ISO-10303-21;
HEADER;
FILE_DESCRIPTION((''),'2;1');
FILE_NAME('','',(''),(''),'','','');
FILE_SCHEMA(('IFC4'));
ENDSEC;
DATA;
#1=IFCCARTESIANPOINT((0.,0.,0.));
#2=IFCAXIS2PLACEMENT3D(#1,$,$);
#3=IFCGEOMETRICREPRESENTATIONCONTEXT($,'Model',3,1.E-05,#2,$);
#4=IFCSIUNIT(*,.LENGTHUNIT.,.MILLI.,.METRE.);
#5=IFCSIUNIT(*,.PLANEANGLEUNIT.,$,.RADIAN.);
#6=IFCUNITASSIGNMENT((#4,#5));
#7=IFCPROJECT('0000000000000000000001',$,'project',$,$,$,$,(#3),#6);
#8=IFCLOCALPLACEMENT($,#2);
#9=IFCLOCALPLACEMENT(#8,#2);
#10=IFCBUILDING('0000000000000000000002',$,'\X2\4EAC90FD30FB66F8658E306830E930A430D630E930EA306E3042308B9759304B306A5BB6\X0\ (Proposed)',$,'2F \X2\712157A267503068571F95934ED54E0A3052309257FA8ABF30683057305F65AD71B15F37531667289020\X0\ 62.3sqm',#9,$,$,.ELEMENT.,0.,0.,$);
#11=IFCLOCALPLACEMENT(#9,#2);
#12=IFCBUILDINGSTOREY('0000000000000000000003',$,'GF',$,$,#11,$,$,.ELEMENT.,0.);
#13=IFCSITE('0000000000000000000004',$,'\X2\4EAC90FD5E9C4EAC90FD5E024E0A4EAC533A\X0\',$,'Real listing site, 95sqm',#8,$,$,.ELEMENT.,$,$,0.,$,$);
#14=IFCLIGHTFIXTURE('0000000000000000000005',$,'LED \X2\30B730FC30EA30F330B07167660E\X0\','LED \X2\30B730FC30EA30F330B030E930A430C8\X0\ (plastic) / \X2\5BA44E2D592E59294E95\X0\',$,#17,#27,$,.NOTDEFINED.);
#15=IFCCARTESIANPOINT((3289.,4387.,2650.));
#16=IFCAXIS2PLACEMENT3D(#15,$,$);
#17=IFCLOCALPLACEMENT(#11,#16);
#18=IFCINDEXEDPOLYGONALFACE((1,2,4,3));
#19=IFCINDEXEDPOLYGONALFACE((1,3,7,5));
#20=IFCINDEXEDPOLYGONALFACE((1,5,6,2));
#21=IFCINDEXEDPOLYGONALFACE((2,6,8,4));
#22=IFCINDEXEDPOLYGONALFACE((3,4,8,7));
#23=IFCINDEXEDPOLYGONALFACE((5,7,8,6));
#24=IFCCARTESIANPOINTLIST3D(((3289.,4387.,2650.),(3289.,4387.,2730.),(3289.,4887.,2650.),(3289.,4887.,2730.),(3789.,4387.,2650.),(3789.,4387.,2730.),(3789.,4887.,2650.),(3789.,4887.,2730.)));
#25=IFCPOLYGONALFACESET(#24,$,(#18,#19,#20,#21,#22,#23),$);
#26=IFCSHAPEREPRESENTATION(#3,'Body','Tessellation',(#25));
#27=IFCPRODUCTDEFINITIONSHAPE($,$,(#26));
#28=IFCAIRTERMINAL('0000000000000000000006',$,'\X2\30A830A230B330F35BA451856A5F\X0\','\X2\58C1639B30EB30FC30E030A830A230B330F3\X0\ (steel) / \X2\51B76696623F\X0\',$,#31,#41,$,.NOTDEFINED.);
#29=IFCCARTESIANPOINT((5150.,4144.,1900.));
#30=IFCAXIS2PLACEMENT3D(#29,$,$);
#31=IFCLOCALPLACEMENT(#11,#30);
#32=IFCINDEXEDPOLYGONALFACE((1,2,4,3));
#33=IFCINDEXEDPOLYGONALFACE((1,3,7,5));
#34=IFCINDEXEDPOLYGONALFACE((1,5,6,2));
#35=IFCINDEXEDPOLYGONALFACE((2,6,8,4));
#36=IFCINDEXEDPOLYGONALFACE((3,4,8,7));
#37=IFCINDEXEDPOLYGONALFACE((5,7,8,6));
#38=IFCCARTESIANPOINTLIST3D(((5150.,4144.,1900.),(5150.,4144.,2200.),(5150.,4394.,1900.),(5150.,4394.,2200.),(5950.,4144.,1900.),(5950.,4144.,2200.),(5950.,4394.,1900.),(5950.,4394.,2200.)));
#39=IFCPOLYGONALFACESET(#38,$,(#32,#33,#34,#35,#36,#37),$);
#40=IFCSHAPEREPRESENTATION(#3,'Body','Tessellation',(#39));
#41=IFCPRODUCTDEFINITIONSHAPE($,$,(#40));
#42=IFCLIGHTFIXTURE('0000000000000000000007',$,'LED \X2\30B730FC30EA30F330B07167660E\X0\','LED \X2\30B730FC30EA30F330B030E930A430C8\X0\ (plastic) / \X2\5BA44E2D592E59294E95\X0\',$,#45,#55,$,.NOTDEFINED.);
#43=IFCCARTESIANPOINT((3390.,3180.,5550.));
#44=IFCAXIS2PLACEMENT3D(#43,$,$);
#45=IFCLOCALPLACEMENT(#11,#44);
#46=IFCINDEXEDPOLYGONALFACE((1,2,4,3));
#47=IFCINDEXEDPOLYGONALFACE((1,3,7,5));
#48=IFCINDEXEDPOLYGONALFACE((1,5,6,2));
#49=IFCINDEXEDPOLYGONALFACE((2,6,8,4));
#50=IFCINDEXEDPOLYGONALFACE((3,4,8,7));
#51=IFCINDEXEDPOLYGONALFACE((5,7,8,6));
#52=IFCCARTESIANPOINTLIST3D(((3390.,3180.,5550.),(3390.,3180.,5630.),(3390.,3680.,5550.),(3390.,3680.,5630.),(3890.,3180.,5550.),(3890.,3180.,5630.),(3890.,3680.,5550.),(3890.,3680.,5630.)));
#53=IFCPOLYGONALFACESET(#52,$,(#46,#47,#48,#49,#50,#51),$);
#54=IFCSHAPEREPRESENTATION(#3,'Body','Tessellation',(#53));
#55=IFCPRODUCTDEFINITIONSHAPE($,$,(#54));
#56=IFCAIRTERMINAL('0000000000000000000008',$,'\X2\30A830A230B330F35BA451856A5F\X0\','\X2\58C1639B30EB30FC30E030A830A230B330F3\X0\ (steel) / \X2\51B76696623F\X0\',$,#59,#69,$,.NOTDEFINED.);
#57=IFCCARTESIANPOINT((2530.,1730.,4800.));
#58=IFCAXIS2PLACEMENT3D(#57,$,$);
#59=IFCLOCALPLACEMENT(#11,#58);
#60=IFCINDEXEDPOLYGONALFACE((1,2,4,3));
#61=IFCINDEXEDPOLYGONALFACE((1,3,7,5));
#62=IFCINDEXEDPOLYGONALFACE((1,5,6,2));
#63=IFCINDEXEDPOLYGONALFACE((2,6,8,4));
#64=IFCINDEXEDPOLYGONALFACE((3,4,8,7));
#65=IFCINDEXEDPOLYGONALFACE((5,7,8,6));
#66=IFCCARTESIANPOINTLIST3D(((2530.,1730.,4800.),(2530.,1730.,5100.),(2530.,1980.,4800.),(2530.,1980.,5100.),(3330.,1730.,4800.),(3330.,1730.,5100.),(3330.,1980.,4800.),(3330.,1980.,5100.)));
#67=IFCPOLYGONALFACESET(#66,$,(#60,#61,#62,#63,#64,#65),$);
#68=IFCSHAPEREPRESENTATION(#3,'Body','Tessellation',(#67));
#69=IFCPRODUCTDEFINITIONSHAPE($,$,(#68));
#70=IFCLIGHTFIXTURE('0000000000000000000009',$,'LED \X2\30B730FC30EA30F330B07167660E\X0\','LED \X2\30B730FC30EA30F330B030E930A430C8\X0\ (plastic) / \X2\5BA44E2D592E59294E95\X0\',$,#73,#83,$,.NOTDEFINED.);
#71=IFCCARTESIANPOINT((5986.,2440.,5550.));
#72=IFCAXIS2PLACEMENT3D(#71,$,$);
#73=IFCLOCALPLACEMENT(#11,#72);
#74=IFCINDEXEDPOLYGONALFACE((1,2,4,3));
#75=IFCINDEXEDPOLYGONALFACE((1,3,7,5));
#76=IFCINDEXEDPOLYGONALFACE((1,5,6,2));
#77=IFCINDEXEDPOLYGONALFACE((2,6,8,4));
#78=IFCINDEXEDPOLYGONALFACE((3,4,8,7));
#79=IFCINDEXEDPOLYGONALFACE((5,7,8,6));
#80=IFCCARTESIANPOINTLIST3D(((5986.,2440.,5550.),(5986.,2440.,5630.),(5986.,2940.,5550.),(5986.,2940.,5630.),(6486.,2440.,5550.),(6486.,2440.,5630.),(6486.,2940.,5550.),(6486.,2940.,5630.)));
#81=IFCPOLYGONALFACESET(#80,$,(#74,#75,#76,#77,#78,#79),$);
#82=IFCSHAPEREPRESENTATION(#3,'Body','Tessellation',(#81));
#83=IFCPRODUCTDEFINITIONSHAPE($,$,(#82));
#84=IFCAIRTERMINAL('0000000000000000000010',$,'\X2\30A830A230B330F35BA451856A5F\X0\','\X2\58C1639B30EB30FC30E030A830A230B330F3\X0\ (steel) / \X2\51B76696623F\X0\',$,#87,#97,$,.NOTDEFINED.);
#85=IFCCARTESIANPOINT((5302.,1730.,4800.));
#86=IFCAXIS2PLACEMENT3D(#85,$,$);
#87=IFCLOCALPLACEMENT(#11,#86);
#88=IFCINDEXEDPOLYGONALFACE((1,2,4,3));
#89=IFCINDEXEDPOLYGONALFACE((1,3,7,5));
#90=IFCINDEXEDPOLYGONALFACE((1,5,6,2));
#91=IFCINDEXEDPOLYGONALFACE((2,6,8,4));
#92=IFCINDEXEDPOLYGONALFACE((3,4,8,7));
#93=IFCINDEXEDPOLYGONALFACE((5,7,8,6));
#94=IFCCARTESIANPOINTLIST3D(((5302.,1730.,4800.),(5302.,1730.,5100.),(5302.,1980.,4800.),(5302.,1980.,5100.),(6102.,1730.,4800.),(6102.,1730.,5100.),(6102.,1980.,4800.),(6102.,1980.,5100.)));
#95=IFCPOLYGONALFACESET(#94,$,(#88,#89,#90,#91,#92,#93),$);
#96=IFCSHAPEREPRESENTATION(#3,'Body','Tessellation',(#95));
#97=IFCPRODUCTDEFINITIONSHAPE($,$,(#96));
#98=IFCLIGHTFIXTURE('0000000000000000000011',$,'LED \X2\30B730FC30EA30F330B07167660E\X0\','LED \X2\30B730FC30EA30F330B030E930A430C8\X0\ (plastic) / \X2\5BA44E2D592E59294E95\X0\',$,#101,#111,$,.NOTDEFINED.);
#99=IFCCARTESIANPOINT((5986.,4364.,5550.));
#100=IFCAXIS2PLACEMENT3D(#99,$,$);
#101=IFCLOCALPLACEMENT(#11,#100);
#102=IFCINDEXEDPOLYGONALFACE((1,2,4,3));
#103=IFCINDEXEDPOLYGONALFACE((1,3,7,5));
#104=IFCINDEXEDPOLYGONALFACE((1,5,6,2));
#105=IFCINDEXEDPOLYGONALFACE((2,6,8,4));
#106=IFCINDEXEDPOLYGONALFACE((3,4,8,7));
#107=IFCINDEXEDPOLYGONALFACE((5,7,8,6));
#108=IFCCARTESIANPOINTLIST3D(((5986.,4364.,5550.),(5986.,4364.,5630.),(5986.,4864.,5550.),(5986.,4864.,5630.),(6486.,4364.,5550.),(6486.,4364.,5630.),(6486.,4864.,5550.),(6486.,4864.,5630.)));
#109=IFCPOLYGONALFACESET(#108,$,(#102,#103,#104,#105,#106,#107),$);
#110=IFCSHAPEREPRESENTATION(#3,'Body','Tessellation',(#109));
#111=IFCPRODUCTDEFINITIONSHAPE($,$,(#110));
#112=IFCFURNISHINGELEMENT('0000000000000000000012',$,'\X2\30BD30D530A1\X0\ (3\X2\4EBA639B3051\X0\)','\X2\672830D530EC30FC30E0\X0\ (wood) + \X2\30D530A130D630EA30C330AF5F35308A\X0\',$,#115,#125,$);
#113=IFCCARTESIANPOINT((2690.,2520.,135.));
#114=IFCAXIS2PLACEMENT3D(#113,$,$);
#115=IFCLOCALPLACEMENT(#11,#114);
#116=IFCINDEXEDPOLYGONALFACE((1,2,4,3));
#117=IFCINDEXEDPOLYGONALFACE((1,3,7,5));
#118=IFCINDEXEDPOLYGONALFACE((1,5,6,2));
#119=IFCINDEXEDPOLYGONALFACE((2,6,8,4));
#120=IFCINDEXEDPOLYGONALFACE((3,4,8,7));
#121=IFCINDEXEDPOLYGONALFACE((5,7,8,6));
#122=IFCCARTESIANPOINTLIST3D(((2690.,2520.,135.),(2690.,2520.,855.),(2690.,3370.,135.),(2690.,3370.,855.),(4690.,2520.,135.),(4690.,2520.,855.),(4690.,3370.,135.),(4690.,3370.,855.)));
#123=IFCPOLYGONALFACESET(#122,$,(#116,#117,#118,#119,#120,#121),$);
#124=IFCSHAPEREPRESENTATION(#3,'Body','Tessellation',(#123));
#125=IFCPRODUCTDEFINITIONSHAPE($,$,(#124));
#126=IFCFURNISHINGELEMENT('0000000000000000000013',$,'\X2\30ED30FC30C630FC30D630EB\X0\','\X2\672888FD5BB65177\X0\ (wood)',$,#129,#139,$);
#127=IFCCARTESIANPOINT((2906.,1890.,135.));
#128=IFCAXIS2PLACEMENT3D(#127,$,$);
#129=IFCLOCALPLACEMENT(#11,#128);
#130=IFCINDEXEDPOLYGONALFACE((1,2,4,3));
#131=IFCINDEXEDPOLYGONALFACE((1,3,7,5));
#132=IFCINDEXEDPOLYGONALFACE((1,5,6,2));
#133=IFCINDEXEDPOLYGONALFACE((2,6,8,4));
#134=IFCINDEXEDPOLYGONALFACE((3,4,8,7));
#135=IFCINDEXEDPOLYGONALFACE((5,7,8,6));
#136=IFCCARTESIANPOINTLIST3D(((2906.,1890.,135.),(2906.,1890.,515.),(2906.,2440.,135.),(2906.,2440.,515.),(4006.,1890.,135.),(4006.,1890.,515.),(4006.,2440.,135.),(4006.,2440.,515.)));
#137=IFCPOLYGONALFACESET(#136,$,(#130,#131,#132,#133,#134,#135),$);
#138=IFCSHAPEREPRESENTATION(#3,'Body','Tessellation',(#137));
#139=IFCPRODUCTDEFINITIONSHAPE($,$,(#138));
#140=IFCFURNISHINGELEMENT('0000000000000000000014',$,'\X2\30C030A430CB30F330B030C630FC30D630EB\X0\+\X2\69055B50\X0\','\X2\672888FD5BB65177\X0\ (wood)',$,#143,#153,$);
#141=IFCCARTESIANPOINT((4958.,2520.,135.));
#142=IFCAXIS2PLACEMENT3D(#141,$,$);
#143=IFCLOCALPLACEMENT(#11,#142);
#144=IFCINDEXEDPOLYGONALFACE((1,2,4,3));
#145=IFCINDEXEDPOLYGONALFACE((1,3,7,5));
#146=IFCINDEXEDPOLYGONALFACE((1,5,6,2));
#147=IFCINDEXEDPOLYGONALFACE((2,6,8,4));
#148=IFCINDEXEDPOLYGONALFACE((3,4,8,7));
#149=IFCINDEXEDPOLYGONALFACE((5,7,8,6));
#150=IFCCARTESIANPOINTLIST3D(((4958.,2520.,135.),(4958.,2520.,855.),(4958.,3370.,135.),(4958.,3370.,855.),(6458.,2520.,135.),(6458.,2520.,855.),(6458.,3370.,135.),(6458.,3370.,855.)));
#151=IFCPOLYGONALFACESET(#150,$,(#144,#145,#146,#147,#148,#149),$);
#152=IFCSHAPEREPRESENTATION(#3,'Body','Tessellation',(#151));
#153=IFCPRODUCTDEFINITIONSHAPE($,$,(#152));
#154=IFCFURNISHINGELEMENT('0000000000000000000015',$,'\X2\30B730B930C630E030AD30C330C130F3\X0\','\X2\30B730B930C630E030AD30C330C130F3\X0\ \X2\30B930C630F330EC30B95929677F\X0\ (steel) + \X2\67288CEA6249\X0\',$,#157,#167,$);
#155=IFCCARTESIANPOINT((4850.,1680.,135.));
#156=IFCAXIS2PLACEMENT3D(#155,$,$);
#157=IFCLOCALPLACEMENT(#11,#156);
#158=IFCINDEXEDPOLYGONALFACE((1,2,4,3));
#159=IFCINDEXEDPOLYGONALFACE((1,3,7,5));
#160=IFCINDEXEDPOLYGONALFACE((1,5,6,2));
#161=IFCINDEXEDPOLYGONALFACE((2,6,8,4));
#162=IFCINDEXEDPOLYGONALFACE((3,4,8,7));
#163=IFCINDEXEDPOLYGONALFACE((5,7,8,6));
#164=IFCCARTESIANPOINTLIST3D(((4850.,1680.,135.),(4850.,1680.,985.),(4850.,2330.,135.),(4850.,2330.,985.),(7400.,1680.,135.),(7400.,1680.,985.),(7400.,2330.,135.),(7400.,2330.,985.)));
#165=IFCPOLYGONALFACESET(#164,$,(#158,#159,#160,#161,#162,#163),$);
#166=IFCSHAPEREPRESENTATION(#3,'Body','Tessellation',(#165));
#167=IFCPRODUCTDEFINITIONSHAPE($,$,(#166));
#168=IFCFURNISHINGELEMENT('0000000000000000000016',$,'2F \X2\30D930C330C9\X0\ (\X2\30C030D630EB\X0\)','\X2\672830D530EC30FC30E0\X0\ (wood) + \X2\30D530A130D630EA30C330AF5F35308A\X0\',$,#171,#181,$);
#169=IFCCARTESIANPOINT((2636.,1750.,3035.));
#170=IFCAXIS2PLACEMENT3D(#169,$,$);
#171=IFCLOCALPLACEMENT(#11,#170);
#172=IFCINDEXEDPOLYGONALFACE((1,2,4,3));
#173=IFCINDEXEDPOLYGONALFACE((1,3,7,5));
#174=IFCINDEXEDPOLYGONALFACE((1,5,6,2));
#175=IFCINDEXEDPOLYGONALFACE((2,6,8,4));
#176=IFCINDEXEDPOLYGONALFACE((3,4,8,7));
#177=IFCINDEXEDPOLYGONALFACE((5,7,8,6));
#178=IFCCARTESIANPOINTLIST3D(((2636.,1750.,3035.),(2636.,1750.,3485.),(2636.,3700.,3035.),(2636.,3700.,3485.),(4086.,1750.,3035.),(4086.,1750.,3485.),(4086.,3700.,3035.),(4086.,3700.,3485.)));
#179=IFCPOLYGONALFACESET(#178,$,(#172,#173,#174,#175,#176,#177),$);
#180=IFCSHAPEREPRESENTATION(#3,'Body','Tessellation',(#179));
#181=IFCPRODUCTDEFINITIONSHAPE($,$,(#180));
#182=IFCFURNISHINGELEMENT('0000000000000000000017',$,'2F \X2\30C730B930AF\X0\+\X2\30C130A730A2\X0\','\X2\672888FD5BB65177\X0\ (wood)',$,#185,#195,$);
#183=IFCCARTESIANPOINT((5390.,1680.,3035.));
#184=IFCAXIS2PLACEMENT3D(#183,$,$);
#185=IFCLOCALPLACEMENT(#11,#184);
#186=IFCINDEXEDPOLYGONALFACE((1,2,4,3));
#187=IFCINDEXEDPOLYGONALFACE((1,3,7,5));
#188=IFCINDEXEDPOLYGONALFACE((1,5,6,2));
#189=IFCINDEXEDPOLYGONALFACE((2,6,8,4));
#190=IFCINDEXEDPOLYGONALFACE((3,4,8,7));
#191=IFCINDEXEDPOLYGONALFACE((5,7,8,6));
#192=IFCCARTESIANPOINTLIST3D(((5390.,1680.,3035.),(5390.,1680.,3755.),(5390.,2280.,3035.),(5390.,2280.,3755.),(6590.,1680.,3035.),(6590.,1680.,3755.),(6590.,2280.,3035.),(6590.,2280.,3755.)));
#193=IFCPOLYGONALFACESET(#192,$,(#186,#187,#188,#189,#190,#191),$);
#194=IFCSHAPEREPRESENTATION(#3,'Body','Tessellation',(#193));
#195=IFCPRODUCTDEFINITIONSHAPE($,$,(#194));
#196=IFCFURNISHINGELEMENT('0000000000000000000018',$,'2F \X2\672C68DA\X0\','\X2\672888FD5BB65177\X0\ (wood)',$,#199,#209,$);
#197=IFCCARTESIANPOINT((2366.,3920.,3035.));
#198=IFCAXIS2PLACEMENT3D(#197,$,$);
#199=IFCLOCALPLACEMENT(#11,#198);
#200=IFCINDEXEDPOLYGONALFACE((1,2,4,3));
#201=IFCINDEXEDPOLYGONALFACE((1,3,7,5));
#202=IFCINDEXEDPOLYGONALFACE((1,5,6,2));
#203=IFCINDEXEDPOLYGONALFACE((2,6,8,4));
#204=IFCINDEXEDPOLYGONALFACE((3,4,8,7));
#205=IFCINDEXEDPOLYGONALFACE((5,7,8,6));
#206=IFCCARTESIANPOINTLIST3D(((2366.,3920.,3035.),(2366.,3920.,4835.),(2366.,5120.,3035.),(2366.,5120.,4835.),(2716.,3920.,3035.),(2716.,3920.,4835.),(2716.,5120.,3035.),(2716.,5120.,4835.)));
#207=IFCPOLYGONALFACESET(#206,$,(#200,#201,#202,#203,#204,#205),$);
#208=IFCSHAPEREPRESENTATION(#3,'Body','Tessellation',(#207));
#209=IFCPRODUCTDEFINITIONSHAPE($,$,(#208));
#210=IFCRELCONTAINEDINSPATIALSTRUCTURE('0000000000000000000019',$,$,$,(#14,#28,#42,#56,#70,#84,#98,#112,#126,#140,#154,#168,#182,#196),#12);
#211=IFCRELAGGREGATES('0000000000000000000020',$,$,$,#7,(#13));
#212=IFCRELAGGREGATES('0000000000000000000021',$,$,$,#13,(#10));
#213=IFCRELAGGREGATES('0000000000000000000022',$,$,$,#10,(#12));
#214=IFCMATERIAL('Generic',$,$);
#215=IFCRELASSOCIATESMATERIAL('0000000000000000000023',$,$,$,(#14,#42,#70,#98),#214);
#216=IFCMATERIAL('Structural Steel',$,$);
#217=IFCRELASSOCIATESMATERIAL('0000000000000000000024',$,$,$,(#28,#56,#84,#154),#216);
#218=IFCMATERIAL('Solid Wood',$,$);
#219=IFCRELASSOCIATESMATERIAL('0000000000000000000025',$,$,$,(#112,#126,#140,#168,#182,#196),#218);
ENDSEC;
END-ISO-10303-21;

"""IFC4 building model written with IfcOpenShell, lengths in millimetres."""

from ifc_helpers import new_model, si_unit, frame, frame_2d, origin, place, context, project, spatial, rectangle, extrude, material, element, save


model = new_model("IFC4")

# Units and contexts
model_context = context("Model", 3, precision=1e-05, world=origin())
ifc_project = project(units=[si_unit("LENGTHUNIT", "METRE", prefix="MILLI"), si_unit("PLANEANGLEUNIT", "RADIAN")], contexts=[model_context])

# Site, building, storey
site_placement = place(None, origin())
site = spatial("IfcSite", under=ifc_project, at=site_placement, Name="京都府京都市上京区", ObjectType="Real listing site, 95sqm", CompositionType="ELEMENT", RefElevation=0.0)
building_placement = place(site_placement, origin())
building = spatial("IfcBuilding", under=site, at=building_placement, Name="京都・書斎とライブラリのある静かな家 (Proposed)", ObjectType="2F 無垢材と土間仕上げを基調とした断熱強化木造 62.3sqm", CompositionType="ELEMENT", ElevationOfRefHeight=0.0, ElevationOfTerrain=0.0)
storey_placement = place(building_placement, origin())
storey = spatial("IfcBuildingStorey", under=building, at=storey_placement, Name="GF", CompositionType="ELEMENT", Elevation=0.0)

# Shared definitions
ifc_material_1 = material(Name="Solid Wood")

# Shared definitions
ifc_material_2 = material(Name="Structural Steel")

# Shared definitions
ifc_material_3 = material(Name="Generic")

# Light fixture
light_fixture_1_placement = place(storey_placement, frame((3289.0, 4387.0, 2650.0)))
element("IfcLightFixture", 1, at=light_fixture_1_placement, inside=storey, material=ifc_material_3, Name="LED シーリング照明", Description="LED シーリングライト (plastic) / 室中央天井", PredefinedType="NOTDEFINED", context=model_context, shape_type="SweptSolid", body=[
    extrude(rectangle(XDim=500.0, YDim=500.0, at=frame_2d((250.0, 250.0))), frame((3289.0, 4387.0, 2650.0)), (0.0, 0.0, 1.0), 80.0),
])

# Air terminal
air_terminal_1_placement = place(storey_placement, frame((5150.0, 4144.0, 1900.0)))
element("IfcAirTerminal", 2, at=air_terminal_1_placement, inside=storey, material=ifc_material_2, Name="エアコン室内機", Description="壁掛ルームエアコン (steel) / 冷暖房", PredefinedType="NOTDEFINED", context=model_context, shape_type="SweptSolid", body=[
    extrude(rectangle(XDim=800.0, YDim=250.0, at=frame_2d((400.0, 125.0))), frame((5150.0, 4144.0, 1900.0)), (0.0, 0.0, 1.0), 300.0),
])

# Light fixture
light_fixture_2_placement = place(storey_placement, frame((3390.0, 3180.0, 5550.0)))
element("IfcLightFixture", 3, at=light_fixture_2_placement, inside=storey, material=ifc_material_3, Name="LED シーリング照明", Description="LED シーリングライト (plastic) / 室中央天井", PredefinedType="NOTDEFINED", context=model_context, shape_type="SweptSolid", body=[
    extrude(rectangle(XDim=500.0, YDim=500.0, at=frame_2d((250.0, 250.0))), frame((3390.0, 3180.0, 5550.0)), (0.0, 0.0, 1.0), 80.0),
])

# Air terminal
air_terminal_2_placement = place(storey_placement, frame((2530.0, 1730.0, 4800.0)))
element("IfcAirTerminal", 4, at=air_terminal_2_placement, inside=storey, material=ifc_material_2, Name="エアコン室内機", Description="壁掛ルームエアコン (steel) / 冷暖房", PredefinedType="NOTDEFINED", context=model_context, shape_type="SweptSolid", body=[
    extrude(rectangle(XDim=800.0, YDim=250.0, at=frame_2d((400.0, 125.0))), frame((2530.0, 1730.0, 4800.0)), (0.0, 0.0, 1.0), 300.0),
])

# Light fixture
light_fixture_3_placement = place(storey_placement, frame((5986.0, 2440.0, 5550.0)))
element("IfcLightFixture", 5, at=light_fixture_3_placement, inside=storey, material=ifc_material_3, Name="LED シーリング照明", Description="LED シーリングライト (plastic) / 室中央天井", PredefinedType="NOTDEFINED", context=model_context, shape_type="SweptSolid", body=[
    extrude(rectangle(XDim=500.0, YDim=500.0, at=frame_2d((250.0, 250.0))), frame((5986.0, 2440.0, 5550.0)), (0.0, 0.0, 1.0), 80.0),
])

# Air terminal
air_terminal_3_placement = place(storey_placement, frame((5302.0, 1730.0, 4800.0)))
element("IfcAirTerminal", 6, at=air_terminal_3_placement, inside=storey, material=ifc_material_2, Name="エアコン室内機", Description="壁掛ルームエアコン (steel) / 冷暖房", PredefinedType="NOTDEFINED", context=model_context, shape_type="SweptSolid", body=[
    extrude(rectangle(XDim=800.0, YDim=250.0, at=frame_2d((400.0, 125.0))), frame((5302.0, 1730.0, 4800.0)), (0.0, 0.0, 1.0), 300.0),
])

# Light fixture
light_fixture_4_placement = place(storey_placement, frame((5986.0, 4364.0, 5550.0)))
element("IfcLightFixture", 7, at=light_fixture_4_placement, inside=storey, material=ifc_material_3, Name="LED シーリング照明", Description="LED シーリングライト (plastic) / 室中央天井", PredefinedType="NOTDEFINED", context=model_context, shape_type="SweptSolid", body=[
    extrude(rectangle(XDim=500.0, YDim=500.0, at=frame_2d((250.0, 250.0))), frame((5986.0, 4364.0, 5550.0)), (0.0, 0.0, 1.0), 80.0),
])

# Furnishing elements
furnishing_1_placement = place(storey_placement, frame((2690.0, 2520.0, 135.0)))
element("IfcFurnishingElement", 8, at=furnishing_1_placement, inside=storey, material=ifc_material_1, Name="ソファ (3人掛け)", Description="木フレーム (wood) + ファブリック張り", context=model_context, shape_type="SweptSolid", body=[
    extrude(rectangle(XDim=2000.0, YDim=850.0, at=frame_2d((1000.0, 425.0))), frame((2690.0, 2520.0, 135.0)), (0.0, 0.0, 1.0), 720.0),
])
furnishing_2_placement = place(storey_placement, frame((2906.0, 1890.0, 135.0)))
element("IfcFurnishingElement", 9, at=furnishing_2_placement, inside=storey, material=ifc_material_1, Name="ローテーブル", Description="木製家具 (wood)", context=model_context, shape_type="SweptSolid", body=[
    extrude(rectangle(XDim=1100.0, YDim=550.0, at=frame_2d((550.0, 275.0))), frame((2906.0, 1890.0, 135.0)), (0.0, 0.0, 1.0), 380.0),
])
furnishing_3_placement = place(storey_placement, frame((4958.0, 2520.0, 135.0)))
element("IfcFurnishingElement", 10, at=furnishing_3_placement, inside=storey, material=ifc_material_1, Name="ダイニングテーブル+椅子", Description="木製家具 (wood)", context=model_context, shape_type="SweptSolid", body=[
    extrude(rectangle(XDim=1500.0, YDim=850.0, at=frame_2d((750.0, 425.0))), frame((4958.0, 2520.0, 135.0)), (0.0, 0.0, 1.0), 720.0),
])
furnishing_4_placement = place(storey_placement, frame((4850.0, 1680.0, 135.0)))
element("IfcFurnishingElement", 11, at=furnishing_4_placement, inside=storey, material=ifc_material_2, Name="システムキッチン", Description="システムキッチン ステンレス天板 (steel) + 木質扉", context=model_context, shape_type="SweptSolid", body=[
    extrude(rectangle(XDim=2550.0, YDim=650.0, at=frame_2d((1275.0, 325.0))), frame((4850.0, 1680.0, 135.0)), (0.0, 0.0, 1.0), 850.0),
])
furnishing_5_placement = place(storey_placement, frame((2636.0, 1750.0, 3035.0)))
element("IfcFurnishingElement", 12, at=furnishing_5_placement, inside=storey, material=ifc_material_1, Name="2F ベッド (ダブル)", Description="木フレーム (wood) + ファブリック張り", context=model_context, shape_type="SweptSolid", body=[
    extrude(rectangle(XDim=1450.0, YDim=1950.0, at=frame_2d((725.0, 975.0))), frame((2636.0, 1750.0, 3035.0)), (0.0, 0.0, 1.0), 450.0),
])
furnishing_6_placement = place(storey_placement, frame((5390.0, 1680.0, 3035.0)))
element("IfcFurnishingElement", 13, at=furnishing_6_placement, inside=storey, material=ifc_material_1, Name="2F デスク+チェア", Description="木製家具 (wood)", context=model_context, shape_type="SweptSolid", body=[
    extrude(rectangle(XDim=1200.0, YDim=600.0, at=frame_2d((600.0, 300.0))), frame((5390.0, 1680.0, 3035.0)), (0.0, 0.0, 1.0), 720.0),
])
furnishing_7_placement = place(storey_placement, frame((2366.0, 3920.0, 3035.0)))
element("IfcFurnishingElement", 14, at=furnishing_7_placement, inside=storey, material=ifc_material_1, Name="2F 本棚", Description="木製家具 (wood)", context=model_context, shape_type="SweptSolid", body=[
    extrude(rectangle(XDim=350.0, YDim=1200.0, at=frame_2d((175.0, 600.0))), frame((2366.0, 3920.0, 3035.0)), (0.0, 0.0, 1.0), 1800.0),
])

save(model, "model.ifc")
